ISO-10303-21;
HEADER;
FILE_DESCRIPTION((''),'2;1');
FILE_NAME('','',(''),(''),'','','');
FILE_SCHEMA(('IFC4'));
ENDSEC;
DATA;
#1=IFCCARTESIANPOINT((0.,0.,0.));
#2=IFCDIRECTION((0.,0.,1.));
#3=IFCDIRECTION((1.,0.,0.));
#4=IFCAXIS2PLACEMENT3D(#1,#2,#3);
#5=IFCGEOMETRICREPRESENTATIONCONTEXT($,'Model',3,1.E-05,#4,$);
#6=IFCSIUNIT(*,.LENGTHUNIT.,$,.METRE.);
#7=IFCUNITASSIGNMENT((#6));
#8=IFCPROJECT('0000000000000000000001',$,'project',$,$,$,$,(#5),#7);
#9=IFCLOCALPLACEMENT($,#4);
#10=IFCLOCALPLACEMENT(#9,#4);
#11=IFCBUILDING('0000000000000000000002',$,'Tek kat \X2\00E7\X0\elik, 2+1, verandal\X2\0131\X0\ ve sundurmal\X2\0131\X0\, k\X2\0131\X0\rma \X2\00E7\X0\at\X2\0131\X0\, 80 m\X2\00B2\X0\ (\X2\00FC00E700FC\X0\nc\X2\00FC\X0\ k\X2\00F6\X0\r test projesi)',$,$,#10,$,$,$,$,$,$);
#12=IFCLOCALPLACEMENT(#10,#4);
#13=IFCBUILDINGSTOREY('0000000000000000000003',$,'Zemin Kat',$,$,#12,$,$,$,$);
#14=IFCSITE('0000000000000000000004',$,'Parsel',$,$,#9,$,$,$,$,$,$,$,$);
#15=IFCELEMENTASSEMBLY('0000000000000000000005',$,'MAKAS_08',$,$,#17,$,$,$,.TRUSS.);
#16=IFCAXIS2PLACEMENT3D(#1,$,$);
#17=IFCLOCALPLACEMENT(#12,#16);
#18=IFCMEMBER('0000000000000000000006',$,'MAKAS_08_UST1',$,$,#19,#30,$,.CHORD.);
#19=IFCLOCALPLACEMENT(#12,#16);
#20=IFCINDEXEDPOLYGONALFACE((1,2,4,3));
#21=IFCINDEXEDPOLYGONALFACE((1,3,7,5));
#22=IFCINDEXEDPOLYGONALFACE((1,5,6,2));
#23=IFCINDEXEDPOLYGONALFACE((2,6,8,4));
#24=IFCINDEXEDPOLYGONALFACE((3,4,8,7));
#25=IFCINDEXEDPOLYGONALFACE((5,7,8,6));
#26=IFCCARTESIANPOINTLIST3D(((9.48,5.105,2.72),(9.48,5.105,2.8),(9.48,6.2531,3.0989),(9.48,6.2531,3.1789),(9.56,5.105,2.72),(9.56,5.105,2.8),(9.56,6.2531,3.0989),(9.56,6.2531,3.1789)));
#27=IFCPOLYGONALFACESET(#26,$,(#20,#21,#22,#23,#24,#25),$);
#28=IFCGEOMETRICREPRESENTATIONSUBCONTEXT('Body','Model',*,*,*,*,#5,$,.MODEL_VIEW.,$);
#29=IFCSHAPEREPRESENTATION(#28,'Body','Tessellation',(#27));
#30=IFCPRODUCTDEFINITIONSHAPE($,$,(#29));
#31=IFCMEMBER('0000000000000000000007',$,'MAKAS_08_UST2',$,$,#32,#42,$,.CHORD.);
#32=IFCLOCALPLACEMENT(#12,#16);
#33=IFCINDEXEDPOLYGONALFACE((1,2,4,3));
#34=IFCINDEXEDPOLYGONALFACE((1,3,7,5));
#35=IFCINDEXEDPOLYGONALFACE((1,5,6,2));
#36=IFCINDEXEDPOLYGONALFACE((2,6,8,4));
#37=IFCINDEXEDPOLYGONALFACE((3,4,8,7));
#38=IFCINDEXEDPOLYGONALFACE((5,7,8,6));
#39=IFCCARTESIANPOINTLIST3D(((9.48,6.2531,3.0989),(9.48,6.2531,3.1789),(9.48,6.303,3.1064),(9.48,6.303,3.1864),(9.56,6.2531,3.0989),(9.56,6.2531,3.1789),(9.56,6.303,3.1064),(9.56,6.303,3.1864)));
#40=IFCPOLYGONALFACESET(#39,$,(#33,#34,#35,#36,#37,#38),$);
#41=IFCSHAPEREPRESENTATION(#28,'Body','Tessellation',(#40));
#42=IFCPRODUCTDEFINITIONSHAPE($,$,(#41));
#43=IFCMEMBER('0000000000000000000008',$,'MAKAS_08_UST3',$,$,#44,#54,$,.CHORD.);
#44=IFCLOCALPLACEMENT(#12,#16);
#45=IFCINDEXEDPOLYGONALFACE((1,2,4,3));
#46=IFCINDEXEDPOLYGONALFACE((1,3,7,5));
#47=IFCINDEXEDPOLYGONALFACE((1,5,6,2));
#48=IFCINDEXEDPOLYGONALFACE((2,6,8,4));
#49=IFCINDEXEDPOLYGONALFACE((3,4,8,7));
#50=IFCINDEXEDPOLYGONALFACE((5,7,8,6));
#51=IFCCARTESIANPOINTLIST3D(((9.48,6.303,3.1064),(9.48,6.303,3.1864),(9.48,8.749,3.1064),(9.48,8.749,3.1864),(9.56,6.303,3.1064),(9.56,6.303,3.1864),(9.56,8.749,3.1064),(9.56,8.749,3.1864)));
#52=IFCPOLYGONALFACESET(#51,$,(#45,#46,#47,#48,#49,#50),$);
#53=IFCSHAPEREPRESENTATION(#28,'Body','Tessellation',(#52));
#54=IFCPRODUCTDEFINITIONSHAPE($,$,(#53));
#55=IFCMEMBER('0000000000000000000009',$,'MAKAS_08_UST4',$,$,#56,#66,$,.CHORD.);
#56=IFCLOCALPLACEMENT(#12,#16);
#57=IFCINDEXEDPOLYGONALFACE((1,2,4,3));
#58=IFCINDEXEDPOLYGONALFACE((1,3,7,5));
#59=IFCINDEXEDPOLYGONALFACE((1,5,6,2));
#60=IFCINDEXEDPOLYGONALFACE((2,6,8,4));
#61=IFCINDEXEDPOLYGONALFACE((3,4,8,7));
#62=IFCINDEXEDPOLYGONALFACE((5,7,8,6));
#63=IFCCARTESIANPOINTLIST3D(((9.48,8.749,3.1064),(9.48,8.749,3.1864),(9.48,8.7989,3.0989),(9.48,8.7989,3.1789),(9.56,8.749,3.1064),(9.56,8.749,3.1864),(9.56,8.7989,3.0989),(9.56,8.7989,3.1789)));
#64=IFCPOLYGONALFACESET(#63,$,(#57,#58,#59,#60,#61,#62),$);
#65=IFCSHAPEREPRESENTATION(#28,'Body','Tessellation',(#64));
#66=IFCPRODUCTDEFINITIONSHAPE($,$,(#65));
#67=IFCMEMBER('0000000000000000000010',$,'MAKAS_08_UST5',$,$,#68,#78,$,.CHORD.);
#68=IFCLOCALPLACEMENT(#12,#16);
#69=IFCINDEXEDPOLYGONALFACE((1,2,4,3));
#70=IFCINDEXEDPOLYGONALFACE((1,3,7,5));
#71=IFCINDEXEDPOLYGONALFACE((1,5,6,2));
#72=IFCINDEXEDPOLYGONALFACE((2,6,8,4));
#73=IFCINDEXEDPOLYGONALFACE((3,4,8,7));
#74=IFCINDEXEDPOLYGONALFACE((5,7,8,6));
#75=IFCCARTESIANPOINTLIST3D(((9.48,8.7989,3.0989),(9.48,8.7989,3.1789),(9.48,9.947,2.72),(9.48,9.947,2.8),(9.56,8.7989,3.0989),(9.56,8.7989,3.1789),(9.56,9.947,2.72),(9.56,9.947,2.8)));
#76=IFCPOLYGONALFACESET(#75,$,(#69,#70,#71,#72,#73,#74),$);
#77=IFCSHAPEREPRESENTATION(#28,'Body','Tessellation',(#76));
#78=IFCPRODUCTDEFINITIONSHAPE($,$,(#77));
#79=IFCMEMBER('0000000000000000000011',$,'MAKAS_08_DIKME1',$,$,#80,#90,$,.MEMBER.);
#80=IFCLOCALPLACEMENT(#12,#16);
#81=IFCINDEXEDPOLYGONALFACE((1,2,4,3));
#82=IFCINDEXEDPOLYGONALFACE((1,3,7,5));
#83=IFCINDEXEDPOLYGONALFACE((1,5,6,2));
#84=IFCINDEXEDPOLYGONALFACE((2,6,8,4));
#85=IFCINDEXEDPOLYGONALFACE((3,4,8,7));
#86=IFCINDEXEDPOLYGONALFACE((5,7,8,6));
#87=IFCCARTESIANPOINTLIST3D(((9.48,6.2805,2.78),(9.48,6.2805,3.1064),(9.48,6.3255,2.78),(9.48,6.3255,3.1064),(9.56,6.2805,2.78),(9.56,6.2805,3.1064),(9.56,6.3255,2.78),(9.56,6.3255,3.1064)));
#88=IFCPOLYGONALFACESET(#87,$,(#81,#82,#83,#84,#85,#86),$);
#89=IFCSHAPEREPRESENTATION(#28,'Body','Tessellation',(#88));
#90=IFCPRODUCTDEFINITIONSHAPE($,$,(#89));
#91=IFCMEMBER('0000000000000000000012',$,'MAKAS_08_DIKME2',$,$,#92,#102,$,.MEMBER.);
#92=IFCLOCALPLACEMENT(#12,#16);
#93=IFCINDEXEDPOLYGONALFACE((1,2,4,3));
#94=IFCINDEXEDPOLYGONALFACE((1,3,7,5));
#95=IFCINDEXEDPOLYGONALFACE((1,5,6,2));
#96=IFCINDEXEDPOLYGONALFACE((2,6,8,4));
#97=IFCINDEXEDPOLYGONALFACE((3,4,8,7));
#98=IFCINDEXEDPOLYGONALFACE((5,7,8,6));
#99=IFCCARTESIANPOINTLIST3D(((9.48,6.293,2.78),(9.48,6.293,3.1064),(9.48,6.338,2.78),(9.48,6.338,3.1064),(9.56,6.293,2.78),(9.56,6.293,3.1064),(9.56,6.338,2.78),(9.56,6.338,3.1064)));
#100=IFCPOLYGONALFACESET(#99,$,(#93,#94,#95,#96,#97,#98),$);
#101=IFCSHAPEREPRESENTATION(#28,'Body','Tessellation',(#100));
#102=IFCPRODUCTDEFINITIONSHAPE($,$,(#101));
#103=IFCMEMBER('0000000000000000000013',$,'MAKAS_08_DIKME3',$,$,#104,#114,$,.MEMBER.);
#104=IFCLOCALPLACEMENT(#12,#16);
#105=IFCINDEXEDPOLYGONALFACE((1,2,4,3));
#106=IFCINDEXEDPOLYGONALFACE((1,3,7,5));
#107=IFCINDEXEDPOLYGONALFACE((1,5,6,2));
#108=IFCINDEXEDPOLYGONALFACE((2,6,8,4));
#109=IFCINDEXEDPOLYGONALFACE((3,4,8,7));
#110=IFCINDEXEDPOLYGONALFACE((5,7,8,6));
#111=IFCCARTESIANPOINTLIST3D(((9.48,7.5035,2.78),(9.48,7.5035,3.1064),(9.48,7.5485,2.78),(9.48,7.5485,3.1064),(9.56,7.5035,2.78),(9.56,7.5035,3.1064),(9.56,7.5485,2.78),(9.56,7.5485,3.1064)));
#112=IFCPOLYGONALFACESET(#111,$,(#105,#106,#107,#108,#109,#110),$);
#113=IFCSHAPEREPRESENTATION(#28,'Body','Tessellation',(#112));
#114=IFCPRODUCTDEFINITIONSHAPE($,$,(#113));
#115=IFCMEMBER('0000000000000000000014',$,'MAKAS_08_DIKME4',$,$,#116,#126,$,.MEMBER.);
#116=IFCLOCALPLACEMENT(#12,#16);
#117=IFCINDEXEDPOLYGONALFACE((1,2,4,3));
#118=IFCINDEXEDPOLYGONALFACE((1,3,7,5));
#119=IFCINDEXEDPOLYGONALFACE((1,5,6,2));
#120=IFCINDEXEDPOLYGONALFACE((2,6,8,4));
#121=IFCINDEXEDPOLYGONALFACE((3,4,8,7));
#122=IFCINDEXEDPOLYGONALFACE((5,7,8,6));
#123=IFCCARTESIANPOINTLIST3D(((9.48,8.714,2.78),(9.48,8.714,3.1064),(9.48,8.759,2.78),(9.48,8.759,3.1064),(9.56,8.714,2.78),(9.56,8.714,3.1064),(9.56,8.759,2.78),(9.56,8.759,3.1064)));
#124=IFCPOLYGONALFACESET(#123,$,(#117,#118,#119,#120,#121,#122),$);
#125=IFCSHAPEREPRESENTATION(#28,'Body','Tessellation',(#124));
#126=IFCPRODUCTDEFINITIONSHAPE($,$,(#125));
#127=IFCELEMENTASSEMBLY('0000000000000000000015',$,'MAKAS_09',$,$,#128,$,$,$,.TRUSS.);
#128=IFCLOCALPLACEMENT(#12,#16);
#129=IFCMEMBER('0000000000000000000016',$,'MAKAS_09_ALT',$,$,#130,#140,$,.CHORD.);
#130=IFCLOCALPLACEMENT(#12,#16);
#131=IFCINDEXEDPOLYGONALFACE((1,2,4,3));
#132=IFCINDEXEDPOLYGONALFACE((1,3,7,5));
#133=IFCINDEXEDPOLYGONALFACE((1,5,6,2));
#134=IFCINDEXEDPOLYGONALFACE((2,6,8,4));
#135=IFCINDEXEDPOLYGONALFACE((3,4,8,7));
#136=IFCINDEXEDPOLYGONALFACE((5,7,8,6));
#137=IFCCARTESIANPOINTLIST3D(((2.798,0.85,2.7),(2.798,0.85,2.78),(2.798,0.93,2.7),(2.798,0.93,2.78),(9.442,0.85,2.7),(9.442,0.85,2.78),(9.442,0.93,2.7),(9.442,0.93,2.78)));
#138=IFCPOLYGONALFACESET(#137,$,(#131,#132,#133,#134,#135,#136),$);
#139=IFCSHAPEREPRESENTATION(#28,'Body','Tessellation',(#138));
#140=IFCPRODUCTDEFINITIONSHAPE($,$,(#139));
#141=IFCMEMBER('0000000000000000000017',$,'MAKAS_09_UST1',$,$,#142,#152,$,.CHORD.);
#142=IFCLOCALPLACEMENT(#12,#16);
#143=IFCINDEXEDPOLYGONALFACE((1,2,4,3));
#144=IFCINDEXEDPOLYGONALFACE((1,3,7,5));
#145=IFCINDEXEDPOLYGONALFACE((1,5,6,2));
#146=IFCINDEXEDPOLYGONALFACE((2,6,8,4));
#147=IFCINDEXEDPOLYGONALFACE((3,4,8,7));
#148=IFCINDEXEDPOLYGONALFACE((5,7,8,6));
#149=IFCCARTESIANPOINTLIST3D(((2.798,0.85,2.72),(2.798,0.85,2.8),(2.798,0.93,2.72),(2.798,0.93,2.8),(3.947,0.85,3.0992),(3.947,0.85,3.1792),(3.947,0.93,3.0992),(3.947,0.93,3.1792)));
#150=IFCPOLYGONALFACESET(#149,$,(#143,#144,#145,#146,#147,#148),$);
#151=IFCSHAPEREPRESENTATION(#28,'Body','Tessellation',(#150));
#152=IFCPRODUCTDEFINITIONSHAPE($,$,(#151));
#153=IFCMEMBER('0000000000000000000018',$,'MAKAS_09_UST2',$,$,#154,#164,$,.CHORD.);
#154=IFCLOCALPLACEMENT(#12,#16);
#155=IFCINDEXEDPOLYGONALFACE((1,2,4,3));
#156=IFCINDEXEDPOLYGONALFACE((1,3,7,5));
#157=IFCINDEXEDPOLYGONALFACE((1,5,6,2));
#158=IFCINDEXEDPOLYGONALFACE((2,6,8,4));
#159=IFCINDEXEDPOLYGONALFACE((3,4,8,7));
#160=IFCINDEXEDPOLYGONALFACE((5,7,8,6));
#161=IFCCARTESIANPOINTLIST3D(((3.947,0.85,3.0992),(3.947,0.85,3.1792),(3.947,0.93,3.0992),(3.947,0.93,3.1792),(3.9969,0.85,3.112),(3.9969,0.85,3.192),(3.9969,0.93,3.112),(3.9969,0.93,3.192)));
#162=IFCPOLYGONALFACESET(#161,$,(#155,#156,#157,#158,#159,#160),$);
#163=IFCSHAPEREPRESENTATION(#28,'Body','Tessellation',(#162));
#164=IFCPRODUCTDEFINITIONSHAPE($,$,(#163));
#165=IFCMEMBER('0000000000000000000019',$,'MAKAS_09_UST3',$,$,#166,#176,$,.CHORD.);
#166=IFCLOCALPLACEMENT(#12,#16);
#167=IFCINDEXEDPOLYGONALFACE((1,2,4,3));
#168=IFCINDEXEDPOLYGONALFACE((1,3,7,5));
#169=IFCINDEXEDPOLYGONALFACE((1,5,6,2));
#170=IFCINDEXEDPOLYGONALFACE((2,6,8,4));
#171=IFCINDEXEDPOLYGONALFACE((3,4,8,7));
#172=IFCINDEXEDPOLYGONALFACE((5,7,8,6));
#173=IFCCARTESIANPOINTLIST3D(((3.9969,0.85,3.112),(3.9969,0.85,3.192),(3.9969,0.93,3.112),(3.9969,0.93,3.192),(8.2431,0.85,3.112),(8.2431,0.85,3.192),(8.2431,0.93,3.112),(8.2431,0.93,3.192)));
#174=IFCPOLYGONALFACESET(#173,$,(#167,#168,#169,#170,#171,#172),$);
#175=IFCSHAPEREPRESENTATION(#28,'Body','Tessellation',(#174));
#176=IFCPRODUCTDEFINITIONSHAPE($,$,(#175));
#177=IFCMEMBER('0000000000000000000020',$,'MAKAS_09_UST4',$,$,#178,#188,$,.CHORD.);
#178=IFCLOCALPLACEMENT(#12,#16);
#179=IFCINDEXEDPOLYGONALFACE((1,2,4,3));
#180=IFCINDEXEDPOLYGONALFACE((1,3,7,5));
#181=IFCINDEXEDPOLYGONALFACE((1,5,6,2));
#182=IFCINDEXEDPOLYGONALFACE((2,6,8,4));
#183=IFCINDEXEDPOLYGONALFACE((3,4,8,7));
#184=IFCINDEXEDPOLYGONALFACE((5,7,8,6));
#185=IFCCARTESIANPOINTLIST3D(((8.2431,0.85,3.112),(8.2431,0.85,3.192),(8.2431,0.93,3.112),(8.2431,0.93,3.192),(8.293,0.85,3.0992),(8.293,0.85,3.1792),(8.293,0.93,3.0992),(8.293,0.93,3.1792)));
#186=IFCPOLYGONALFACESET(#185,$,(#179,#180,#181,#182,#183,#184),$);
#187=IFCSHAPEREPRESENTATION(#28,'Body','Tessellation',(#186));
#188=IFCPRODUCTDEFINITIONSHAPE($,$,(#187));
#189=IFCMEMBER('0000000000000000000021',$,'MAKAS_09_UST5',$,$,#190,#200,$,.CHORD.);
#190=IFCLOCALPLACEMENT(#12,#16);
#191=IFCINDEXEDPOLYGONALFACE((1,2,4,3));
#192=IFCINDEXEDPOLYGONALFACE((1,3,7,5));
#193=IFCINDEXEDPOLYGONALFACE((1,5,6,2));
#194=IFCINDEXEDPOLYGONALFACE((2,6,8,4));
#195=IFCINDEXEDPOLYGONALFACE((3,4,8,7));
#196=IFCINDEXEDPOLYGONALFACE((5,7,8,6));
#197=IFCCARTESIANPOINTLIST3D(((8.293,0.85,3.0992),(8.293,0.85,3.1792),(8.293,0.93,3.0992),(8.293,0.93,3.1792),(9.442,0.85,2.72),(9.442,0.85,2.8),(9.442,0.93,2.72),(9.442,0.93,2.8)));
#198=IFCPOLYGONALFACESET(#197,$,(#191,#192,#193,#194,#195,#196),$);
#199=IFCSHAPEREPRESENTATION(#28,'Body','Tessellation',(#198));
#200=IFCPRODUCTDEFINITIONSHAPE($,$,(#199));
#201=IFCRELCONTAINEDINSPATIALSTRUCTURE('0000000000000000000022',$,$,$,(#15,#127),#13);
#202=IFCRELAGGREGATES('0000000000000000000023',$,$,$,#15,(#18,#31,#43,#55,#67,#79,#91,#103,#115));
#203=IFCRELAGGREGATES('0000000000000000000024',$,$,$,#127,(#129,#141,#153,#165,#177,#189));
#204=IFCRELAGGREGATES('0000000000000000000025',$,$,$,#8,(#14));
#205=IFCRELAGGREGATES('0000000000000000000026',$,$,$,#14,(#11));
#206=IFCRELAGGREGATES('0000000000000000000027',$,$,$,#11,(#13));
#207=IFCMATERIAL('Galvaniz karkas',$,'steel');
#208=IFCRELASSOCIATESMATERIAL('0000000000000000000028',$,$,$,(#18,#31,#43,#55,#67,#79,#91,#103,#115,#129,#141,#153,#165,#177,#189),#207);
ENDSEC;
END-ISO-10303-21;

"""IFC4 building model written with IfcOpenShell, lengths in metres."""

from ifc_helpers import new_model, si_unit, frame, origin_with_axes, place, context, subcontext, project, spatial, line, indexed_curve, outline, extrude, material, element, aggregate, save


model = new_model("IFC4")

# Units and contexts
model_context = context("Model", 3, precision=1e-05, world=origin_with_axes())
body_context = subcontext(model_context, "Body", "Model", "MODEL_VIEW")
ifc_project = project(units=[si_unit("LENGTHUNIT", "METRE")], contexts=[model_context])

# Site, building, storey
site_placement = place(None, origin_with_axes())
site = spatial("IfcSite", under=ifc_project, at=site_placement, Name="Parsel")
building_placement = place(site_placement, origin_with_axes())
building = spatial("IfcBuilding", under=site, at=building_placement, Name="Tek kat çelik, 2+1, verandalı ve sundurmalı, kırma çatı, 80 m² (üçüncü kör test projesi)")
storey_placement = place(building_placement, origin_with_axes())
storey = spatial("IfcBuildingStorey", under=building, at=storey_placement, Name="Zemin Kat")

# Element assemblies, members
assembly_1_placement = place(storey_placement, origin_with_axes())
assembly_1 = element("IfcElementAssembly", 1, at=assembly_1_placement, inside=storey, Name="MAKAS_08", PredefinedType="TRUSS")
ifc_material = material(Name="Galvaniz karkas", Category="steel")
member_1_placement = place(assembly_1_placement, origin_with_axes())
member_1 = element("IfcMember", 2, at=member_1_placement, material=ifc_material, Name="MAKAS_08_UST1", PredefinedType="CHORD", context=body_context, shape_type="SweptSolid", body=[
    extrude(outline(indexed_curve([(5.105, 2.72), (6.2531, 3.0989), (6.2531, 3.1789), (5.105, 2.8)], segments=[line(1, 2, 3, 4, 1)])), frame((9.48, 0.0, 0.0), z_axis=(1.0, 0.0, 0.0), x_axis=(0.0, 1.0, 0.0)), (0.0, 0.0, 1.0), 0.08),
])
member_2_placement = place(assembly_1_placement, origin_with_axes())
member_2 = element("IfcMember", 3, at=member_2_placement, material=ifc_material, Name="MAKAS_08_UST2", PredefinedType="CHORD", context=body_context, shape_type="SweptSolid", body=[
    extrude(outline(indexed_curve([(6.2531, 3.0989), (6.303, 3.1064), (6.303, 3.1864), (6.2531, 3.1789)], segments=[line(1, 2, 3, 4, 1)])), frame((9.48, 0.0, 0.0), z_axis=(1.0, 0.0, 0.0), x_axis=(0.0, 1.0, 0.0)), (0.0, 0.0, 1.0), 0.08),
])
member_3_placement = place(assembly_1_placement, origin_with_axes())
member_3 = element("IfcMember", 4, at=member_3_placement, material=ifc_material, Name="MAKAS_08_UST3", PredefinedType="CHORD", context=body_context, shape_type="SweptSolid", body=[
    extrude(outline(indexed_curve([(6.303, 3.1064), (8.749, 3.1064), (8.749, 3.1864), (6.303, 3.1864)], segments=[line(1, 2, 3, 4, 1)])), frame((9.48, 0.0, 0.0), z_axis=(1.0, 0.0, 0.0), x_axis=(0.0, 1.0, 0.0)), (0.0, 0.0, 1.0), 0.08),
])
member_4_placement = place(assembly_1_placement, origin_with_axes())
member_4 = element("IfcMember", 5, at=member_4_placement, material=ifc_material, Name="MAKAS_08_UST4", PredefinedType="CHORD", context=body_context, shape_type="SweptSolid", body=[
    extrude(outline(indexed_curve([(8.749, 3.1064), (8.7989, 3.0989), (8.7989, 3.1789), (8.749, 3.1864)], segments=[line(1, 2, 3, 4, 1)])), frame((9.48, 0.0, 0.0), z_axis=(1.0, 0.0, 0.0), x_axis=(0.0, 1.0, 0.0)), (0.0, 0.0, 1.0), 0.08),
])
member_5_placement = place(assembly_1_placement, origin_with_axes())
member_5 = element("IfcMember", 6, at=member_5_placement, material=ifc_material, Name="MAKAS_08_UST5", PredefinedType="CHORD", context=body_context, shape_type="SweptSolid", body=[
    extrude(outline(indexed_curve([(8.7989, 3.0989), (9.947, 2.72), (9.947, 2.8), (8.7989, 3.1789)], segments=[line(1, 2, 3, 4, 1)])), frame((9.48, 0.0, 0.0), z_axis=(1.0, 0.0, 0.0), x_axis=(0.0, 1.0, 0.0)), (0.0, 0.0, 1.0), 0.08),
])
member_6_placement = place(assembly_1_placement, origin_with_axes())
member_6 = element("IfcMember", 7, at=member_6_placement, material=ifc_material, Name="MAKAS_08_DIKME1", PredefinedType="MEMBER", context=body_context, shape_type="SweptSolid", body=[
    extrude(outline(indexed_curve([(6.2805, 2.78), (6.3255, 2.78), (6.3255, 3.1064), (6.2805, 3.1064)], segments=[line(1, 2, 3, 4, 1)])), frame((9.48, 0.0, 0.0), z_axis=(1.0, 0.0, 0.0), x_axis=(0.0, 1.0, 0.0)), (0.0, 0.0, 1.0), 0.08),
])
member_7_placement = place(assembly_1_placement, origin_with_axes())
member_7 = element("IfcMember", 8, at=member_7_placement, material=ifc_material, Name="MAKAS_08_DIKME2", PredefinedType="MEMBER", context=body_context, shape_type="SweptSolid", body=[
    extrude(outline(indexed_curve([(6.293, 2.78), (6.338, 2.78), (6.338, 3.1064), (6.293, 3.1064)], segments=[line(1, 2, 3, 4, 1)])), frame((9.48, 0.0, 0.0), z_axis=(1.0, 0.0, 0.0), x_axis=(0.0, 1.0, 0.0)), (0.0, 0.0, 1.0), 0.08),
])
member_8_placement = place(assembly_1_placement, origin_with_axes())
member_8 = element("IfcMember", 9, at=member_8_placement, material=ifc_material, Name="MAKAS_08_DIKME3", PredefinedType="MEMBER", context=body_context, shape_type="SweptSolid", body=[
    extrude(outline(indexed_curve([(7.5035, 2.78), (7.5485, 2.78), (7.5485, 3.1064), (7.5035, 3.1064)], segments=[line(1, 2, 3, 4, 1)])), frame((9.48, 0.0, 0.0), z_axis=(1.0, 0.0, 0.0), x_axis=(0.0, 1.0, 0.0)), (0.0, 0.0, 1.0), 0.08),
])
member_9_placement = place(assembly_1_placement, origin_with_axes())
member_9 = element("IfcMember", 10, at=member_9_placement, material=ifc_material, Name="MAKAS_08_DIKME4", PredefinedType="MEMBER", context=body_context, shape_type="SweptSolid", body=[
    extrude(outline(indexed_curve([(8.714, 2.78), (8.759, 2.78), (8.759, 3.1064), (8.714, 3.1064)], segments=[line(1, 2, 3, 4, 1)])), frame((9.48, 0.0, 0.0), z_axis=(1.0, 0.0, 0.0), x_axis=(0.0, 1.0, 0.0)), (0.0, 0.0, 1.0), 0.08),
])
aggregate(assembly_1, [member_1, member_2, member_3, member_4, member_5, member_6, member_7, member_8, member_9])
assembly_2_placement = place(storey_placement, origin_with_axes())
assembly_2 = element("IfcElementAssembly", 11, at=assembly_2_placement, inside=storey, Name="MAKAS_09", PredefinedType="TRUSS")
member_10_placement = place(assembly_2_placement, origin_with_axes())
member_10 = element("IfcMember", 12, at=member_10_placement, material=ifc_material, Name="MAKAS_09_ALT", PredefinedType="CHORD", context=body_context, shape_type="SweptSolid", body=[
    extrude(outline(indexed_curve([(2.798, 2.7), (9.442, 2.7), (9.442, 2.78), (2.798, 2.78)], segments=[line(1, 2, 3, 4, 1)])), frame((0.0, 0.93, 0.0), z_axis=(0.0, -1.0, 0.0), x_axis=(1.0, 0.0, 0.0)), (0.0, 0.0, 1.0), 0.08),
])
member_11_placement = place(assembly_2_placement, origin_with_axes())
member_11 = element("IfcMember", 13, at=member_11_placement, material=ifc_material, Name="MAKAS_09_UST1", PredefinedType="CHORD", context=body_context, shape_type="SweptSolid", body=[
    extrude(outline(indexed_curve([(2.798, 2.72), (3.947, 3.0992), (3.947, 3.1792), (2.798, 2.8)], segments=[line(1, 2, 3, 4, 1)])), frame((0.0, 0.93, 0.0), z_axis=(0.0, -1.0, 0.0), x_axis=(1.0, 0.0, 0.0)), (0.0, 0.0, 1.0), 0.08),
])
member_12_placement = place(assembly_2_placement, origin_with_axes())
member_12 = element("IfcMember", 14, at=member_12_placement, material=ifc_material, Name="MAKAS_09_UST2", PredefinedType="CHORD", context=body_context, shape_type="SweptSolid", body=[
    extrude(outline(indexed_curve([(3.947, 3.0992), (3.9969, 3.112), (3.9969, 3.192), (3.947, 3.1792)], segments=[line(1, 2, 3, 4, 1)])), frame((0.0, 0.93, 0.0), z_axis=(0.0, -1.0, 0.0), x_axis=(1.0, 0.0, 0.0)), (0.0, 0.0, 1.0), 0.08),
])
member_13_placement = place(assembly_2_placement, origin_with_axes())
member_13 = element("IfcMember", 15, at=member_13_placement, material=ifc_material, Name="MAKAS_09_UST3", PredefinedType="CHORD", context=body_context, shape_type="SweptSolid", body=[
    extrude(outline(indexed_curve([(3.9969, 3.112), (8.2431, 3.112), (8.2431, 3.192), (3.9969, 3.192)], segments=[line(1, 2, 3, 4, 1)])), frame((0.0, 0.93, 0.0), z_axis=(0.0, -1.0, 0.0), x_axis=(1.0, 0.0, 0.0)), (0.0, 0.0, 1.0), 0.08),
])
member_14_placement = place(assembly_2_placement, origin_with_axes())
member_14 = element("IfcMember", 16, at=member_14_placement, material=ifc_material, Name="MAKAS_09_UST4", PredefinedType="CHORD", context=body_context, shape_type="SweptSolid", body=[
    extrude(outline(indexed_curve([(8.2431, 3.112), (8.293, 3.0992), (8.293, 3.1792), (8.2431, 3.192)], segments=[line(1, 2, 3, 4, 1)])), frame((0.0, 0.93, 0.0), z_axis=(0.0, -1.0, 0.0), x_axis=(1.0, 0.0, 0.0)), (0.0, 0.0, 1.0), 0.08),
])
member_15_placement = place(assembly_2_placement, origin_with_axes())
member_15 = element("IfcMember", 17, at=member_15_placement, material=ifc_material, Name="MAKAS_09_UST5", PredefinedType="CHORD", context=body_context, shape_type="SweptSolid", body=[
    extrude(outline(indexed_curve([(8.293, 3.0992), (9.442, 2.72), (9.442, 2.8), (8.293, 3.1792)], segments=[line(1, 2, 3, 4, 1)])), frame((0.0, 0.93, 0.0), z_axis=(0.0, -1.0, 0.0), x_axis=(1.0, 0.0, 0.0)), (0.0, 0.0, 1.0), 0.08),
])
aggregate(assembly_2, [member_10, member_11, member_12, member_13, member_14, member_15])

save(model, "model.ifc")
